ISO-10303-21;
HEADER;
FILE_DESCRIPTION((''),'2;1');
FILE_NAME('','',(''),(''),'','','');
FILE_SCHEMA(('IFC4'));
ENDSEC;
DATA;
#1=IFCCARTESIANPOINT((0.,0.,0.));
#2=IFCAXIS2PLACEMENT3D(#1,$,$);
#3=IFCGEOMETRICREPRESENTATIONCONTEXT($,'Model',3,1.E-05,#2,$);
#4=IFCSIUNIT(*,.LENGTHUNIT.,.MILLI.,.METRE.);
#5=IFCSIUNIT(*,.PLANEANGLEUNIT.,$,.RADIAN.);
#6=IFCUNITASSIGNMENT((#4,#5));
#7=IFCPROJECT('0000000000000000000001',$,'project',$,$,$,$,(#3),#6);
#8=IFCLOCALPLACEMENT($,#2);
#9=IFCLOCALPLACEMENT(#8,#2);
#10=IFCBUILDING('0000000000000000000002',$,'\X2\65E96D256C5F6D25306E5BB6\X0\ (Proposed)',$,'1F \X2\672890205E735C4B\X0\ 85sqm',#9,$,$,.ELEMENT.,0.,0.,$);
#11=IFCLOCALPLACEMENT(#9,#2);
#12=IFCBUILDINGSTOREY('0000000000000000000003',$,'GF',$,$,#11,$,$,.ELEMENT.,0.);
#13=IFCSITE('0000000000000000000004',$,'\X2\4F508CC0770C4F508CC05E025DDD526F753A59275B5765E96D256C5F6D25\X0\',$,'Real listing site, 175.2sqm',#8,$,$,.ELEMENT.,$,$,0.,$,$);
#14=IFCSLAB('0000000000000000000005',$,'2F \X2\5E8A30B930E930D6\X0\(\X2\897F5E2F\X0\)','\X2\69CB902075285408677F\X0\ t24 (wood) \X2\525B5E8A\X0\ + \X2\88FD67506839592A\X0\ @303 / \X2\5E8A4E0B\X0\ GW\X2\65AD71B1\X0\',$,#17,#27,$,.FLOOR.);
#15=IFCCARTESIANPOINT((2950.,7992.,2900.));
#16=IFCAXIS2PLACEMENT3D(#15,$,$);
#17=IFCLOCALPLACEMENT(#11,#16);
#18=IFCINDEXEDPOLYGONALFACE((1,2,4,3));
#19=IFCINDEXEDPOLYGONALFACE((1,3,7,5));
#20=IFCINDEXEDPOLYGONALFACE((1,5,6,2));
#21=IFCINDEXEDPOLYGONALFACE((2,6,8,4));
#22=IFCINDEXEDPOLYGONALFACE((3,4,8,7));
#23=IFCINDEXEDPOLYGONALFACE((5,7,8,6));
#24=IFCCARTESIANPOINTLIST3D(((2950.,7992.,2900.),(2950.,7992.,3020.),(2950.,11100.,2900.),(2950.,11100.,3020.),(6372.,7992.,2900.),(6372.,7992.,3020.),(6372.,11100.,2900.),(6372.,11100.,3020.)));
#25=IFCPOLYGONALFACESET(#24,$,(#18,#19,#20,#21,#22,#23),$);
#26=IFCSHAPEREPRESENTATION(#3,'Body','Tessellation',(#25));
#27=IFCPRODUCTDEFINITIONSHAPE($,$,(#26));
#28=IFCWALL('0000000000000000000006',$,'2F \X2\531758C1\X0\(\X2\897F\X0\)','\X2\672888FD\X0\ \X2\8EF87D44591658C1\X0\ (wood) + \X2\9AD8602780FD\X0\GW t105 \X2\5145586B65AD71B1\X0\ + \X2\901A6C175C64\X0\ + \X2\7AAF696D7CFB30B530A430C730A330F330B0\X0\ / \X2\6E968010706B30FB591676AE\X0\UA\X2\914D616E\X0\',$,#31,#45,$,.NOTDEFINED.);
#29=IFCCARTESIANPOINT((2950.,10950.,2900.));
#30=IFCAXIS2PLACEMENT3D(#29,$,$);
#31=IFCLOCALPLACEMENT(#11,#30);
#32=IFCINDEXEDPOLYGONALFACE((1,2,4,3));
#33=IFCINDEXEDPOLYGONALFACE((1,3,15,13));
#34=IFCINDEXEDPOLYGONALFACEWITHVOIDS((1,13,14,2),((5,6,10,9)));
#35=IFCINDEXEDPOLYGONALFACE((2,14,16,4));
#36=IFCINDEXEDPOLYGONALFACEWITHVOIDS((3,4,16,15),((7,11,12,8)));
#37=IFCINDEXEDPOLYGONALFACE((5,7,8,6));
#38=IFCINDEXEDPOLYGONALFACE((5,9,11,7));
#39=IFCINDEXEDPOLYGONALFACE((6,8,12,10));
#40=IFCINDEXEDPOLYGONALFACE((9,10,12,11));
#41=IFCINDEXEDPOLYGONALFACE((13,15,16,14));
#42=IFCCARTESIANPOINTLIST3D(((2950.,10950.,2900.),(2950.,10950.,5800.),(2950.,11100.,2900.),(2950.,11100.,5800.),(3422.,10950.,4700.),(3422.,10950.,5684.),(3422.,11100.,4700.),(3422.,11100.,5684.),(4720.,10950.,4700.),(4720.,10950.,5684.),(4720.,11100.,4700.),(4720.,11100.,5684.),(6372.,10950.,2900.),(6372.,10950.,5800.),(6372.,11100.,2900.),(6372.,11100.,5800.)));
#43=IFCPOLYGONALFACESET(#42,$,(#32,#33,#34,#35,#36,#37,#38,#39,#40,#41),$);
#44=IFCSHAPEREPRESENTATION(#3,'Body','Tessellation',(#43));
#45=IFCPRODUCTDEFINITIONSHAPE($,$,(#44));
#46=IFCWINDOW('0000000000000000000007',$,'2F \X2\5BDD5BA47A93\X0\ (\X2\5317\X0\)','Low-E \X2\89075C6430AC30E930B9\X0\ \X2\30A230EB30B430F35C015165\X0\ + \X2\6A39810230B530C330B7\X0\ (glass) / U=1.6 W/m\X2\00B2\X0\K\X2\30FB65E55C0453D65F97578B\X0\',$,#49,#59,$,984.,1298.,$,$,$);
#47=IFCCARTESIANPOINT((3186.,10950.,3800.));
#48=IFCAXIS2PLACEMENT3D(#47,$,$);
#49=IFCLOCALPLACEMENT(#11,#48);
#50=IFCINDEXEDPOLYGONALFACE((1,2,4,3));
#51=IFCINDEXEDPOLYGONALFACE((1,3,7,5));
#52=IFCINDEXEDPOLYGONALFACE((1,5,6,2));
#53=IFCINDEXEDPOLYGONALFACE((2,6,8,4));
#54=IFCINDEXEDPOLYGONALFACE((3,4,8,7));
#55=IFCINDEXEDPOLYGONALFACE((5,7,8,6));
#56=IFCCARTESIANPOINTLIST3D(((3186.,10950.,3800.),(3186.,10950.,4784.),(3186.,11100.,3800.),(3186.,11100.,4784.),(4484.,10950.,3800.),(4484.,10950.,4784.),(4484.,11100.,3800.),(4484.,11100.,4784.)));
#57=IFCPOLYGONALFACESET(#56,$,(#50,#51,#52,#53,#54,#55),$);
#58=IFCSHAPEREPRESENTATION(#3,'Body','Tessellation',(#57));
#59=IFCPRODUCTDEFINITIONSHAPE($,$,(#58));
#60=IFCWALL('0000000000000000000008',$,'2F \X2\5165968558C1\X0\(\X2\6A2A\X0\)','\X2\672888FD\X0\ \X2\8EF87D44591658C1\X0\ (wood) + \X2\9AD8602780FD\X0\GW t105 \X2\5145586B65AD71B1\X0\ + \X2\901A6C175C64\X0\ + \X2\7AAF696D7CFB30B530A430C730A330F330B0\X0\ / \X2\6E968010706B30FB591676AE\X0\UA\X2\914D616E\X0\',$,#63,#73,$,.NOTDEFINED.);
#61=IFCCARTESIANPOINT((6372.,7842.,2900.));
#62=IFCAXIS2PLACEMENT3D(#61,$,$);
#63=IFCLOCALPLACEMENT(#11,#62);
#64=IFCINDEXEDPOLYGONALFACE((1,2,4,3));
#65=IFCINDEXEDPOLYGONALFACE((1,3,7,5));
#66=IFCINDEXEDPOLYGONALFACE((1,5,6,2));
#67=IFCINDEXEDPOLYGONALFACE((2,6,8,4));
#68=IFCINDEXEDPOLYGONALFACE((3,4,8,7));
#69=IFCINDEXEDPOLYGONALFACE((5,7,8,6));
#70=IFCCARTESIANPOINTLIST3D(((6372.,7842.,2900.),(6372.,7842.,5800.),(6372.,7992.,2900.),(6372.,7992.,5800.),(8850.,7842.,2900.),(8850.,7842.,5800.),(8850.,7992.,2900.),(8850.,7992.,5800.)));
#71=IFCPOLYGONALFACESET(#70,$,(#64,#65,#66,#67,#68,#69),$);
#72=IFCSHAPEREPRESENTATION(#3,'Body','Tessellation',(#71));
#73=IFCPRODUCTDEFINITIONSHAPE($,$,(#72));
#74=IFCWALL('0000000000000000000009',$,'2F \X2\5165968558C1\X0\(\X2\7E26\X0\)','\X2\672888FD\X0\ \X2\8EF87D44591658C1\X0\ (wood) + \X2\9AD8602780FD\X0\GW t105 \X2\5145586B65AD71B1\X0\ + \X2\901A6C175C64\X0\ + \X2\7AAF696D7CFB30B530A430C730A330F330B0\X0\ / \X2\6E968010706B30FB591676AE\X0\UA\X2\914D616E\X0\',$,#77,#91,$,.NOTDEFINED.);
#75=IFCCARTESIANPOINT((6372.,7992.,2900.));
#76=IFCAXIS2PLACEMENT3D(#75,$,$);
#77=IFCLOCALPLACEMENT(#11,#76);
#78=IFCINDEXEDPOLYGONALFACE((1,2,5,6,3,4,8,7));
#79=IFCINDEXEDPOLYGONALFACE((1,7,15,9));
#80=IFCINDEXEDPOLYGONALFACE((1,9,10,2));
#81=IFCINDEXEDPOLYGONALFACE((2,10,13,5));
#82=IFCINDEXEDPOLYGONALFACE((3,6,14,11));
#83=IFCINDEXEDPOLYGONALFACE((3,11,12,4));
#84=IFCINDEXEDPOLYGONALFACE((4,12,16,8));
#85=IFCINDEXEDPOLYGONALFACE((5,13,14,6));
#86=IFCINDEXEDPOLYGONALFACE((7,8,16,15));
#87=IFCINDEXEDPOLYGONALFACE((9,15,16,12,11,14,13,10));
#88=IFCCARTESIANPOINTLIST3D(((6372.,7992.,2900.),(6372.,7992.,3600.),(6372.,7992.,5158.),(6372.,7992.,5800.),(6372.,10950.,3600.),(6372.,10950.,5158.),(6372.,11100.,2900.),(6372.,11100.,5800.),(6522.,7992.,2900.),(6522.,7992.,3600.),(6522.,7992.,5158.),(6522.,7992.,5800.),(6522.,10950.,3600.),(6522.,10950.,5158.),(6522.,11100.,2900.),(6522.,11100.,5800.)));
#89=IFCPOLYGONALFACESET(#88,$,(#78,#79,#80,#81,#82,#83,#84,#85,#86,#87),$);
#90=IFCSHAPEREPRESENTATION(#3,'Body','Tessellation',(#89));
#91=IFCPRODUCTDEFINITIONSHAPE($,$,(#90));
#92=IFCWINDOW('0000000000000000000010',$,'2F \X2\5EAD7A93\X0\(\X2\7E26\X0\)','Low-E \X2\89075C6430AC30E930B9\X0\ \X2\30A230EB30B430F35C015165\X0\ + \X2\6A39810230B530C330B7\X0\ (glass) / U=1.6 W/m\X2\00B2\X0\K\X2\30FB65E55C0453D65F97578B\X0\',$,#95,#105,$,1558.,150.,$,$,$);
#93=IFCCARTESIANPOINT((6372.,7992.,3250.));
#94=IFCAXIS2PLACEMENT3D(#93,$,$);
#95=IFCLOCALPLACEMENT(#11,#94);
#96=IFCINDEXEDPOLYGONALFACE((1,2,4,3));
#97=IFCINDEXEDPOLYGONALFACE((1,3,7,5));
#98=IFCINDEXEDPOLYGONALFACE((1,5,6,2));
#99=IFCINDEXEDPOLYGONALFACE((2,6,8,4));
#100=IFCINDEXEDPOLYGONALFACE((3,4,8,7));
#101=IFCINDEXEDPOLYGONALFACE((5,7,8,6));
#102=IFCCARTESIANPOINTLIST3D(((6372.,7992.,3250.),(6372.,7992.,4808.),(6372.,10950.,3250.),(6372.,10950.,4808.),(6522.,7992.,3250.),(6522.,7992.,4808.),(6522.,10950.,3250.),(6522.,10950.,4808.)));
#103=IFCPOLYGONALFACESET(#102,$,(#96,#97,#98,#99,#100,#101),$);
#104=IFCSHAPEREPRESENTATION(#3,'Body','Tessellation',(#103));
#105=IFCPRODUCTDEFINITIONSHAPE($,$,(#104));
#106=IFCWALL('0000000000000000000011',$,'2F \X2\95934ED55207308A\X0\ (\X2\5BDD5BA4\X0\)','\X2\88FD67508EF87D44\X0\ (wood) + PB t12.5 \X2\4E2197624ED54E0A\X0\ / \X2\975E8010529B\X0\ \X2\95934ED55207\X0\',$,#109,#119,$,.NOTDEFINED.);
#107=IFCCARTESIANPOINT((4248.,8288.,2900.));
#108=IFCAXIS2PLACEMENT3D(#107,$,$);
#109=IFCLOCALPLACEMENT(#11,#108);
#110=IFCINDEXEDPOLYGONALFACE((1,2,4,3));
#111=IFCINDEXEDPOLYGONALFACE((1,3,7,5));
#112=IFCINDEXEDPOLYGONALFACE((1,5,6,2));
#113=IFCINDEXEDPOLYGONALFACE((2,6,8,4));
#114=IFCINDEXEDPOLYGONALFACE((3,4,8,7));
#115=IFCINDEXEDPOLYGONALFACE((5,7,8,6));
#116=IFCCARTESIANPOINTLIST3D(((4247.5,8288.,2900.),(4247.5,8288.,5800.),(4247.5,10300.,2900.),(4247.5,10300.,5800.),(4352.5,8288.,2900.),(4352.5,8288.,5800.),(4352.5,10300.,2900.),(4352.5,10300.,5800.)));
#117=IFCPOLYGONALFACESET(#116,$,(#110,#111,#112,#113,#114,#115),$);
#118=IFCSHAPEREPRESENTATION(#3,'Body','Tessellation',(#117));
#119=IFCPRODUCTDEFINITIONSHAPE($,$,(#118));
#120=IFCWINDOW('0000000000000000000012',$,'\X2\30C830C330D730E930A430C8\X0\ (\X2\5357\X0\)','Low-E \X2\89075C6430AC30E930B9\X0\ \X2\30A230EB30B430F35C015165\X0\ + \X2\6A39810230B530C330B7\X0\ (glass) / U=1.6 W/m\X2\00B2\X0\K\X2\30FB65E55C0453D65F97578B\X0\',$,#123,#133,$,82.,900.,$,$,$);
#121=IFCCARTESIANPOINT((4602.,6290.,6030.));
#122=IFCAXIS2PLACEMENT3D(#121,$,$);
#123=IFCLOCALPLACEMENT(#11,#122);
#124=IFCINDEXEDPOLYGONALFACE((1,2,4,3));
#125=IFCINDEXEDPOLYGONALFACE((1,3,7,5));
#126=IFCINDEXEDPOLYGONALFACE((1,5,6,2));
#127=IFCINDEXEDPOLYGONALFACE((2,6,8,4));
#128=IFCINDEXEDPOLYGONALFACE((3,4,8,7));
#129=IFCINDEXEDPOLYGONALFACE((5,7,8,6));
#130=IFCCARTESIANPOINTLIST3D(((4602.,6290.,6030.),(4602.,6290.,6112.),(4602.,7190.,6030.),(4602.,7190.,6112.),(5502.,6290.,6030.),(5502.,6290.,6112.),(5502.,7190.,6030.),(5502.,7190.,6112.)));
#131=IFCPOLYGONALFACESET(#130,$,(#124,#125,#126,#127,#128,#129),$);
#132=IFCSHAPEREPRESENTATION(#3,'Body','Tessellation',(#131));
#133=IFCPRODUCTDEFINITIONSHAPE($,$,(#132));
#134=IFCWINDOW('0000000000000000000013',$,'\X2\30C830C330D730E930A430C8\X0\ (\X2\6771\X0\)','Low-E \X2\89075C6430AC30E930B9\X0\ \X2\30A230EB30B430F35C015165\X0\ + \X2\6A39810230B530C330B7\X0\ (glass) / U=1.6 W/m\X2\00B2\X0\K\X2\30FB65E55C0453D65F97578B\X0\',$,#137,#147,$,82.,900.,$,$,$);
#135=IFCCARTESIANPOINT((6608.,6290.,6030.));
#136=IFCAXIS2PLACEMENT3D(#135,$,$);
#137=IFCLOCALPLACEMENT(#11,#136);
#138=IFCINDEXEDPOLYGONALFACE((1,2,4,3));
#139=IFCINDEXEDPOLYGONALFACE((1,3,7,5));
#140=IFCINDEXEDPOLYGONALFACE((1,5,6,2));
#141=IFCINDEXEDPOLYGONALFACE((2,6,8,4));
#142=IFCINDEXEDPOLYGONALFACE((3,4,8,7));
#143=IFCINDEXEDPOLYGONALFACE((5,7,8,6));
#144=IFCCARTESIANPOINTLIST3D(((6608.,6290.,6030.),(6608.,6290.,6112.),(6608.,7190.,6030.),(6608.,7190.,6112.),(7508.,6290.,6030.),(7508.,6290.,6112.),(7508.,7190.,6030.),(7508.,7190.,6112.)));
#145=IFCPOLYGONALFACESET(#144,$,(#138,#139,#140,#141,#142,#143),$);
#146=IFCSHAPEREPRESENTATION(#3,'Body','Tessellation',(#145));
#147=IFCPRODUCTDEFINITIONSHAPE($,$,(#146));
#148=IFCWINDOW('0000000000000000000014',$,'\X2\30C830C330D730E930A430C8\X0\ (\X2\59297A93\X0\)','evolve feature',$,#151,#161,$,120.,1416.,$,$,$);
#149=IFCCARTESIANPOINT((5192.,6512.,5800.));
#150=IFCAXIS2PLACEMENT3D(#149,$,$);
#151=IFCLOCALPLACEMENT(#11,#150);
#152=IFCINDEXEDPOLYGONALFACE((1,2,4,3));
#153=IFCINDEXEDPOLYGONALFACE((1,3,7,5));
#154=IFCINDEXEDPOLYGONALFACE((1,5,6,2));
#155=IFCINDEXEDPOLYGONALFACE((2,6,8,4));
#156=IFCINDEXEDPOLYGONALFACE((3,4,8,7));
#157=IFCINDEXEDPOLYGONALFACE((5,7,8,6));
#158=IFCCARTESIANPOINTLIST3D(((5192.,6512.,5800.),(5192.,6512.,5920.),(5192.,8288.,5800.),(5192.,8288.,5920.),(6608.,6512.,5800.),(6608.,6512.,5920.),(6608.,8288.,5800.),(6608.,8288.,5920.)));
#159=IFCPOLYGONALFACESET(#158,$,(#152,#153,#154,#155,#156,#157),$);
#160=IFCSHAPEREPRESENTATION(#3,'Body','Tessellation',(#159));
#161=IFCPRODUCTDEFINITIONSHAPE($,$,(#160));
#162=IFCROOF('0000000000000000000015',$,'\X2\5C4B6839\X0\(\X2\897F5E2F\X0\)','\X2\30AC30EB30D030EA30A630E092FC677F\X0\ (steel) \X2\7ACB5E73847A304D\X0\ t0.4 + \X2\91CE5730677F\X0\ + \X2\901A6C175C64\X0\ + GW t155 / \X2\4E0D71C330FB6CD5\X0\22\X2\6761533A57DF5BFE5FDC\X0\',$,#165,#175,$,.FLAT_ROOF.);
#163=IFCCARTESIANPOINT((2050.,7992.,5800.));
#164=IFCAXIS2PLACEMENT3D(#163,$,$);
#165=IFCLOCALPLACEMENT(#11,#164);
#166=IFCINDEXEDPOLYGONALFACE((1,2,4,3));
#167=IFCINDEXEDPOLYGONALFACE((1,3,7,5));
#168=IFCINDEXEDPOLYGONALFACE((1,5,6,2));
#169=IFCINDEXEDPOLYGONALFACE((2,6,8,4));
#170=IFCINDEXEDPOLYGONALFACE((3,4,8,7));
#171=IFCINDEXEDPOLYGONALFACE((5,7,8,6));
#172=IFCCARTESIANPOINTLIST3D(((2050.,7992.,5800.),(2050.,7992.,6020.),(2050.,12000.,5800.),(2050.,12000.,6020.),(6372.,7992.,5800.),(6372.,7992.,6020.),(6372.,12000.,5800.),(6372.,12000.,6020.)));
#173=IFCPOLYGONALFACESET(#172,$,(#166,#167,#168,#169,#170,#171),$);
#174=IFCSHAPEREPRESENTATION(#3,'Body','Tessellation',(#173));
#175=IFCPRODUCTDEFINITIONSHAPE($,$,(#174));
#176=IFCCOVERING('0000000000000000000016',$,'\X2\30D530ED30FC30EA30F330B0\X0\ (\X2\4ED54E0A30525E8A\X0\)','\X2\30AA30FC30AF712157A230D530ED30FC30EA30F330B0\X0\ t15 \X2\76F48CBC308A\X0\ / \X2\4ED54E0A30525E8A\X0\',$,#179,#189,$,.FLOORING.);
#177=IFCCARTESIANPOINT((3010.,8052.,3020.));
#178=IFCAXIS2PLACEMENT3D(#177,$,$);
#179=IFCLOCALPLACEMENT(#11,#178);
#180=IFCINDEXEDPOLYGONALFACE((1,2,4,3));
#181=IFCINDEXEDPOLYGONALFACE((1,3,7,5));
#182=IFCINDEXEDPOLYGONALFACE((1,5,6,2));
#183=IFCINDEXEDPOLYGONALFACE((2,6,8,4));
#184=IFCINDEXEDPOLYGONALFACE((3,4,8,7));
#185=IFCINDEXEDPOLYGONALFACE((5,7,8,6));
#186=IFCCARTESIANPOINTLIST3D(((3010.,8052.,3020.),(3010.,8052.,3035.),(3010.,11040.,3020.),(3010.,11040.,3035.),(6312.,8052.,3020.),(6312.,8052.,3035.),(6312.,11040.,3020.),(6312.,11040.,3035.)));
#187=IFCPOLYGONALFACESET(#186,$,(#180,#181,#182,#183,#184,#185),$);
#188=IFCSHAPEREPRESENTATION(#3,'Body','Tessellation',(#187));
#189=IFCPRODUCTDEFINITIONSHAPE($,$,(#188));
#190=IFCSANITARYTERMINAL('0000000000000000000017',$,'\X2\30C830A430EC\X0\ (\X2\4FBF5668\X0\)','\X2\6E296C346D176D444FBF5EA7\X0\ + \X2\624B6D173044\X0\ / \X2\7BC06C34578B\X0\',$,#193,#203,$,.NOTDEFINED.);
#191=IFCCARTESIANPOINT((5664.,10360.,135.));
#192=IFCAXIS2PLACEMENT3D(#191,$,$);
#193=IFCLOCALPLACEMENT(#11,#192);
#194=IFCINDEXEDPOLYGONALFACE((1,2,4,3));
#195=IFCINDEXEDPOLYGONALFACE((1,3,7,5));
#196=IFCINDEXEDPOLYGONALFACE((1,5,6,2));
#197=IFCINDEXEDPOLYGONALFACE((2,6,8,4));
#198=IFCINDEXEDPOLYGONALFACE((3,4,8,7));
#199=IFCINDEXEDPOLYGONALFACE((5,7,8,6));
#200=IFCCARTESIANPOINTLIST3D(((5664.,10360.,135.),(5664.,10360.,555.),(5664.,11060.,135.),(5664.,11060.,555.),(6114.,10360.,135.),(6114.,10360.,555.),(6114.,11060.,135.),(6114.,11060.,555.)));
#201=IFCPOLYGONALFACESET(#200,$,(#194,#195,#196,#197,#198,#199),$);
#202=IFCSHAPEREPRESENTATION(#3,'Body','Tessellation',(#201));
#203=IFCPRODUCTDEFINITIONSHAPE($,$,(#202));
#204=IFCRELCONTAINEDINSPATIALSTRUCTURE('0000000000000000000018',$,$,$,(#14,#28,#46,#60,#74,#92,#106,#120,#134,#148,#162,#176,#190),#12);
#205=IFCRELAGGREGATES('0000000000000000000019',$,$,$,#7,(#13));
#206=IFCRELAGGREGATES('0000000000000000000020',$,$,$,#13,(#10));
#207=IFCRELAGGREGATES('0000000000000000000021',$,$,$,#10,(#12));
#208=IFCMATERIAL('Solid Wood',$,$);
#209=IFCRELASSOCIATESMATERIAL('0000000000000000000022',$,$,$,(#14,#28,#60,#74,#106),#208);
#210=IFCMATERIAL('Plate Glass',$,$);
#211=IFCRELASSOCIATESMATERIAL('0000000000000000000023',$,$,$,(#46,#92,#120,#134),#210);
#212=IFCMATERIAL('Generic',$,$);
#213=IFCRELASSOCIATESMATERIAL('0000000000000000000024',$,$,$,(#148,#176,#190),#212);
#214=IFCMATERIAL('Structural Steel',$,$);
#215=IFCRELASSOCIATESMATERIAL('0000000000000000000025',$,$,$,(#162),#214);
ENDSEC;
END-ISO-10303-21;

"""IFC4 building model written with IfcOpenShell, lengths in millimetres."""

from ifc_helpers import new_model, si_unit, frame, frame_2d, origin, place, context, project, spatial, rectangle, extrude, material, element, fill, save


model = new_model("IFC4")

# Units and contexts
model_context = context("Model", 3, precision=1e-05, world=origin())
ifc_project = project(units=[si_unit("LENGTHUNIT", "METRE", prefix="MILLI"), si_unit("PLANEANGLEUNIT", "RADIAN")], contexts=[model_context])

# Site, building, storey
site_placement = place(None, origin())
site = spatial("IfcSite", under=ifc_project, at=site_placement, Name="佐賀県佐賀市川副町大字早津江津", ObjectType="Real listing site, 175.2sqm", CompositionType="ELEMENT", RefElevation=0.0)
building_placement = place(site_placement, origin())
building = spatial("IfcBuilding", under=site, at=building_placement, Name="早津江津の家 (Proposed)", ObjectType="1F 木造平屋 85sqm", CompositionType="ELEMENT", ElevationOfRefHeight=0.0, ElevationOfTerrain=0.0)
storey_placement = place(building_placement, origin())
storey = spatial("IfcBuildingStorey", under=building, at=storey_placement, Name="GF", CompositionType="ELEMENT", Elevation=0.0)

# Slab
ifc_material_1 = material(Name="Solid Wood")
slab_placement = place(storey_placement, frame((2950.0, 7992.0, 2900.0)))
element("IfcSlab", 1, at=slab_placement, inside=storey, material=ifc_material_1, Name="2F 床スラブ(西帯)", Description="構造用合板 t24 (wood) 剛床 + 製材根太 @303 / 床下 GW断熱", PredefinedType="FLOOR", context=model_context, shape_type="SweptSolid", body=[
    extrude(rectangle(XDim=3422.0, YDim=3108.0, at=frame_2d((1711.0, 1554.0))), frame((2950.0, 7992.0, 2900.0)), (0.0, 0.0, 1.0), 120.0),
])

# Wall, opening, window
wall_1_placement = place(storey_placement, frame((2950.0, 10950.0, 2900.0)))
wall_1 = element("IfcWall", 2, at=wall_1_placement, inside=storey, material=ifc_material_1, Name="2F 北壁(西)", Description="木製 軸組外壁 (wood) + 高性能GW t105 充填断熱 + 通気層 + 窯業系サイディング / 準耐火・外皮UA配慮", PredefinedType="NOTDEFINED", context=model_context, shape_type="SweptSolid", body=[
    extrude(rectangle(XDim=3422.0, YDim=150.0, at=frame_2d((1711.0, 75.0))), frame((2950.0, 10950.0, 2900.0)), (0.0, 0.0, 1.0), 2900.0),
])
opening_1_placement = place(storey_placement, frame((3186.0, 10950.0, 3800.0)))
opening_1 = element("IfcOpeningElement", 3, at=opening_1_placement, cuts=wall_1, PredefinedType="NOTDEFINED", context=model_context, shape_type="SweptSolid", body=[
    extrude(rectangle(XDim=1298.0, YDim=150.0, at=frame_2d((649.0, 75.0))), frame((3186.0, 10950.0, 3800.0)), (0.0, 0.0, 1.0), 984.0),
])
ifc_material_2 = material(Name="Plate Glass")
window_1_placement = place(storey_placement, frame((3186.0, 10950.0, 3800.0)))
window_1 = element("IfcWindow", 4, at=window_1_placement, inside=storey, material=ifc_material_2, Name="2F 寝室窓 (北)", Description="Low-E 複層ガラス アルゴン封入 + 樹脂サッシ (glass) / U=1.6 W/m²K・日射取得型", OverallHeight=984.0, OverallWidth=1298.0, context=model_context, shape_type="SweptSolid", body=[
    extrude(rectangle(XDim=1298.0, YDim=150.0, at=frame_2d((649.0, 75.0))), frame((3186.0, 10950.0, 3800.0)), (0.0, 0.0, 1.0), 984.0),
])
fill(opening_1, window_1)

# Wall
wall_2_placement = place(storey_placement, frame((6372.0, 7842.0, 2900.0)))
element("IfcWall", 5, at=wall_2_placement, inside=storey, material=ifc_material_1, Name="2F 入隅壁(横)", Description="木製 軸組外壁 (wood) + 高性能GW t105 充填断熱 + 通気層 + 窯業系サイディング / 準耐火・外皮UA配慮", PredefinedType="NOTDEFINED", context=model_context, shape_type="SweptSolid", body=[
    extrude(rectangle(XDim=2478.0, YDim=150.0, at=frame_2d((1239.0, 75.0))), frame((6372.0, 7842.0, 2900.0)), (0.0, 0.0, 1.0), 2900.0),
])

# Wall, opening, window
wall_3_placement = place(storey_placement, frame((6372.0, 7992.0, 2900.0)))
wall_3 = element("IfcWall", 6, at=wall_3_placement, inside=storey, material=ifc_material_1, Name="2F 入隅壁(縦)", Description="木製 軸組外壁 (wood) + 高性能GW t105 充填断熱 + 通気層 + 窯業系サイディング / 準耐火・外皮UA配慮", PredefinedType="NOTDEFINED", context=model_context, shape_type="SweptSolid", body=[
    extrude(rectangle(XDim=150.0, YDim=3108.0, at=frame_2d((75.0, 1554.0))), frame((6372.0, 7992.0, 2900.0)), (0.0, 0.0, 1.0), 2900.0),
])
opening_2_placement = place(storey_placement, frame((6372.0, 7992.0, 3250.0)))
opening_2 = element("IfcOpeningElement", 7, at=opening_2_placement, cuts=wall_3, PredefinedType="NOTDEFINED", context=model_context, shape_type="SweptSolid", body=[
    extrude(rectangle(XDim=150.0, YDim=2958.0, at=frame_2d((75.0, 1479.0))), frame((6372.0, 7992.0, 3250.0)), (0.0, 0.0, 1.0), 1558.0),
])
window_2_placement = place(storey_placement, frame((6372.0, 7992.0, 3250.0)))
window_2 = element("IfcWindow", 8, at=window_2_placement, inside=storey, material=ifc_material_2, Name="2F 庭窓(縦)", Description="Low-E 複層ガラス アルゴン封入 + 樹脂サッシ (glass) / U=1.6 W/m²K・日射取得型", OverallHeight=1558.0, OverallWidth=150.0, context=model_context, shape_type="SweptSolid", body=[
    extrude(rectangle(XDim=150.0, YDim=2958.0, at=frame_2d((75.0, 1479.0))), frame((6372.0, 7992.0, 3250.0)), (0.0, 0.0, 1.0), 1558.0),
])
fill(opening_2, window_2)

# Wall
wall_4_placement = place(storey_placement, frame((4248.0, 8288.0, 2900.0)))
element("IfcWall", 9, at=wall_4_placement, inside=storey, material=ifc_material_1, Name="2F 間仕切り (寝室)", Description="製材軸組 (wood) + PB t12.5 両面仕上 / 非耐力 間仕切", PredefinedType="NOTDEFINED", context=model_context, shape_type="SweptSolid", body=[
    extrude(rectangle(XDim=105.0, YDim=2012.0, at=frame_2d((52.0, 1006.0))), frame((4248.0, 8288.0, 2900.0)), (0.0, 0.0, 1.0), 2900.0),
])

# Windows
window_3_placement = place(storey_placement, frame((4602.0, 6290.0, 6030.0)))
element("IfcWindow", 10, at=window_3_placement, inside=storey, material=ifc_material_2, Name="トップライト (南)", Description="Low-E 複層ガラス アルゴン封入 + 樹脂サッシ (glass) / U=1.6 W/m²K・日射取得型", OverallHeight=82.0, OverallWidth=900.0, context=model_context, shape_type="SweptSolid", body=[
    extrude(rectangle(XDim=900.0, YDim=900.0, at=frame_2d((450.0, 450.0))), frame((4602.0, 6290.0, 6030.0)), (0.0, 0.0, 1.0), 82.0),
])
window_4_placement = place(storey_placement, frame((6608.0, 6290.0, 6030.0)))
element("IfcWindow", 11, at=window_4_placement, inside=storey, material=ifc_material_2, Name="トップライト (東)", Description="Low-E 複層ガラス アルゴン封入 + 樹脂サッシ (glass) / U=1.6 W/m²K・日射取得型", OverallHeight=82.0, OverallWidth=900.0, context=model_context, shape_type="SweptSolid", body=[
    extrude(rectangle(XDim=900.0, YDim=900.0, at=frame_2d((450.0, 450.0))), frame((6608.0, 6290.0, 6030.0)), (0.0, 0.0, 1.0), 82.0),
])
ifc_material_3 = material(Name="Generic")
window_5_placement = place(storey_placement, frame((5192.0, 6512.0, 5800.0)))
element("IfcWindow", 12, at=window_5_placement, inside=storey, material=ifc_material_3, Name="トップライト (天窓)", Description="evolve feature", OverallHeight=120.0, OverallWidth=1416.0, context=model_context, shape_type="SweptSolid", body=[
    extrude(rectangle(XDim=1416.0, YDim=1776.0, at=frame_2d((708.0, 888.0))), frame((5192.0, 6512.0, 5800.0)), (0.0, 0.0, 1.0), 120.0),
])

# Roof
ifc_material_4 = material(Name="Structural Steel")
for number, where, name in (
    (13, (2050.0, 7992.0, 5800.0), "屋根(西帯)"),
):
    element("IfcRoof", number, at=place(storey_placement, frame(where)), inside=storey, material=ifc_material_4, Name=name, Description="ガルバリウム鋼板 (steel) 立平葺き t0.4 + 野地板 + 通気層 + GW t155 / 不燃・法22条区域対応", PredefinedType="FLAT_ROOF", context=model_context, shape_type="SweptSolid", body=[
        extrude(rectangle(XDim=4322.0, YDim=4008.0, at=frame_2d((2161.0, 2004.0))), frame((2050.0, 7992.0, 5800.0)), (0.0, 0.0, 1.0), 220.0),
    ])

# Covering
covering_placement = place(storey_placement, frame((3010.0, 8052.0, 3020.0)))
element("IfcCovering", 14, at=covering_placement, inside=storey, material=ifc_material_3, Name="フローリング (仕上げ床)", Description="オーク無垢フローリング t15 直貼り / 仕上げ床", PredefinedType="FLOORING", context=model_context, shape_type="SweptSolid", body=[
    extrude(rectangle(XDim=3302.0, YDim=2988.0, at=frame_2d((1651.0, 1494.0))), frame((3010.0, 8052.0, 3020.0)), (0.0, 0.0, 1.0), 15.0),
])

# Sanitary terminal
sanitary_terminal_placement = place(storey_placement, frame((5664.0, 10360.0, 135.0)))
element("IfcSanitaryTerminal", 15, at=sanitary_terminal_placement, inside=storey, material=ifc_material_3, Name="トイレ (便器)", Description="温水洗浄便座 + 手洗い / 節水型", PredefinedType="NOTDEFINED", context=model_context, shape_type="SweptSolid", body=[
    extrude(rectangle(XDim=450.0, YDim=700.0, at=frame_2d((225.0, 350.0))), frame((5664.0, 10360.0, 135.0)), (0.0, 0.0, 1.0), 420.0),
])

save(model, "model.ifc")
